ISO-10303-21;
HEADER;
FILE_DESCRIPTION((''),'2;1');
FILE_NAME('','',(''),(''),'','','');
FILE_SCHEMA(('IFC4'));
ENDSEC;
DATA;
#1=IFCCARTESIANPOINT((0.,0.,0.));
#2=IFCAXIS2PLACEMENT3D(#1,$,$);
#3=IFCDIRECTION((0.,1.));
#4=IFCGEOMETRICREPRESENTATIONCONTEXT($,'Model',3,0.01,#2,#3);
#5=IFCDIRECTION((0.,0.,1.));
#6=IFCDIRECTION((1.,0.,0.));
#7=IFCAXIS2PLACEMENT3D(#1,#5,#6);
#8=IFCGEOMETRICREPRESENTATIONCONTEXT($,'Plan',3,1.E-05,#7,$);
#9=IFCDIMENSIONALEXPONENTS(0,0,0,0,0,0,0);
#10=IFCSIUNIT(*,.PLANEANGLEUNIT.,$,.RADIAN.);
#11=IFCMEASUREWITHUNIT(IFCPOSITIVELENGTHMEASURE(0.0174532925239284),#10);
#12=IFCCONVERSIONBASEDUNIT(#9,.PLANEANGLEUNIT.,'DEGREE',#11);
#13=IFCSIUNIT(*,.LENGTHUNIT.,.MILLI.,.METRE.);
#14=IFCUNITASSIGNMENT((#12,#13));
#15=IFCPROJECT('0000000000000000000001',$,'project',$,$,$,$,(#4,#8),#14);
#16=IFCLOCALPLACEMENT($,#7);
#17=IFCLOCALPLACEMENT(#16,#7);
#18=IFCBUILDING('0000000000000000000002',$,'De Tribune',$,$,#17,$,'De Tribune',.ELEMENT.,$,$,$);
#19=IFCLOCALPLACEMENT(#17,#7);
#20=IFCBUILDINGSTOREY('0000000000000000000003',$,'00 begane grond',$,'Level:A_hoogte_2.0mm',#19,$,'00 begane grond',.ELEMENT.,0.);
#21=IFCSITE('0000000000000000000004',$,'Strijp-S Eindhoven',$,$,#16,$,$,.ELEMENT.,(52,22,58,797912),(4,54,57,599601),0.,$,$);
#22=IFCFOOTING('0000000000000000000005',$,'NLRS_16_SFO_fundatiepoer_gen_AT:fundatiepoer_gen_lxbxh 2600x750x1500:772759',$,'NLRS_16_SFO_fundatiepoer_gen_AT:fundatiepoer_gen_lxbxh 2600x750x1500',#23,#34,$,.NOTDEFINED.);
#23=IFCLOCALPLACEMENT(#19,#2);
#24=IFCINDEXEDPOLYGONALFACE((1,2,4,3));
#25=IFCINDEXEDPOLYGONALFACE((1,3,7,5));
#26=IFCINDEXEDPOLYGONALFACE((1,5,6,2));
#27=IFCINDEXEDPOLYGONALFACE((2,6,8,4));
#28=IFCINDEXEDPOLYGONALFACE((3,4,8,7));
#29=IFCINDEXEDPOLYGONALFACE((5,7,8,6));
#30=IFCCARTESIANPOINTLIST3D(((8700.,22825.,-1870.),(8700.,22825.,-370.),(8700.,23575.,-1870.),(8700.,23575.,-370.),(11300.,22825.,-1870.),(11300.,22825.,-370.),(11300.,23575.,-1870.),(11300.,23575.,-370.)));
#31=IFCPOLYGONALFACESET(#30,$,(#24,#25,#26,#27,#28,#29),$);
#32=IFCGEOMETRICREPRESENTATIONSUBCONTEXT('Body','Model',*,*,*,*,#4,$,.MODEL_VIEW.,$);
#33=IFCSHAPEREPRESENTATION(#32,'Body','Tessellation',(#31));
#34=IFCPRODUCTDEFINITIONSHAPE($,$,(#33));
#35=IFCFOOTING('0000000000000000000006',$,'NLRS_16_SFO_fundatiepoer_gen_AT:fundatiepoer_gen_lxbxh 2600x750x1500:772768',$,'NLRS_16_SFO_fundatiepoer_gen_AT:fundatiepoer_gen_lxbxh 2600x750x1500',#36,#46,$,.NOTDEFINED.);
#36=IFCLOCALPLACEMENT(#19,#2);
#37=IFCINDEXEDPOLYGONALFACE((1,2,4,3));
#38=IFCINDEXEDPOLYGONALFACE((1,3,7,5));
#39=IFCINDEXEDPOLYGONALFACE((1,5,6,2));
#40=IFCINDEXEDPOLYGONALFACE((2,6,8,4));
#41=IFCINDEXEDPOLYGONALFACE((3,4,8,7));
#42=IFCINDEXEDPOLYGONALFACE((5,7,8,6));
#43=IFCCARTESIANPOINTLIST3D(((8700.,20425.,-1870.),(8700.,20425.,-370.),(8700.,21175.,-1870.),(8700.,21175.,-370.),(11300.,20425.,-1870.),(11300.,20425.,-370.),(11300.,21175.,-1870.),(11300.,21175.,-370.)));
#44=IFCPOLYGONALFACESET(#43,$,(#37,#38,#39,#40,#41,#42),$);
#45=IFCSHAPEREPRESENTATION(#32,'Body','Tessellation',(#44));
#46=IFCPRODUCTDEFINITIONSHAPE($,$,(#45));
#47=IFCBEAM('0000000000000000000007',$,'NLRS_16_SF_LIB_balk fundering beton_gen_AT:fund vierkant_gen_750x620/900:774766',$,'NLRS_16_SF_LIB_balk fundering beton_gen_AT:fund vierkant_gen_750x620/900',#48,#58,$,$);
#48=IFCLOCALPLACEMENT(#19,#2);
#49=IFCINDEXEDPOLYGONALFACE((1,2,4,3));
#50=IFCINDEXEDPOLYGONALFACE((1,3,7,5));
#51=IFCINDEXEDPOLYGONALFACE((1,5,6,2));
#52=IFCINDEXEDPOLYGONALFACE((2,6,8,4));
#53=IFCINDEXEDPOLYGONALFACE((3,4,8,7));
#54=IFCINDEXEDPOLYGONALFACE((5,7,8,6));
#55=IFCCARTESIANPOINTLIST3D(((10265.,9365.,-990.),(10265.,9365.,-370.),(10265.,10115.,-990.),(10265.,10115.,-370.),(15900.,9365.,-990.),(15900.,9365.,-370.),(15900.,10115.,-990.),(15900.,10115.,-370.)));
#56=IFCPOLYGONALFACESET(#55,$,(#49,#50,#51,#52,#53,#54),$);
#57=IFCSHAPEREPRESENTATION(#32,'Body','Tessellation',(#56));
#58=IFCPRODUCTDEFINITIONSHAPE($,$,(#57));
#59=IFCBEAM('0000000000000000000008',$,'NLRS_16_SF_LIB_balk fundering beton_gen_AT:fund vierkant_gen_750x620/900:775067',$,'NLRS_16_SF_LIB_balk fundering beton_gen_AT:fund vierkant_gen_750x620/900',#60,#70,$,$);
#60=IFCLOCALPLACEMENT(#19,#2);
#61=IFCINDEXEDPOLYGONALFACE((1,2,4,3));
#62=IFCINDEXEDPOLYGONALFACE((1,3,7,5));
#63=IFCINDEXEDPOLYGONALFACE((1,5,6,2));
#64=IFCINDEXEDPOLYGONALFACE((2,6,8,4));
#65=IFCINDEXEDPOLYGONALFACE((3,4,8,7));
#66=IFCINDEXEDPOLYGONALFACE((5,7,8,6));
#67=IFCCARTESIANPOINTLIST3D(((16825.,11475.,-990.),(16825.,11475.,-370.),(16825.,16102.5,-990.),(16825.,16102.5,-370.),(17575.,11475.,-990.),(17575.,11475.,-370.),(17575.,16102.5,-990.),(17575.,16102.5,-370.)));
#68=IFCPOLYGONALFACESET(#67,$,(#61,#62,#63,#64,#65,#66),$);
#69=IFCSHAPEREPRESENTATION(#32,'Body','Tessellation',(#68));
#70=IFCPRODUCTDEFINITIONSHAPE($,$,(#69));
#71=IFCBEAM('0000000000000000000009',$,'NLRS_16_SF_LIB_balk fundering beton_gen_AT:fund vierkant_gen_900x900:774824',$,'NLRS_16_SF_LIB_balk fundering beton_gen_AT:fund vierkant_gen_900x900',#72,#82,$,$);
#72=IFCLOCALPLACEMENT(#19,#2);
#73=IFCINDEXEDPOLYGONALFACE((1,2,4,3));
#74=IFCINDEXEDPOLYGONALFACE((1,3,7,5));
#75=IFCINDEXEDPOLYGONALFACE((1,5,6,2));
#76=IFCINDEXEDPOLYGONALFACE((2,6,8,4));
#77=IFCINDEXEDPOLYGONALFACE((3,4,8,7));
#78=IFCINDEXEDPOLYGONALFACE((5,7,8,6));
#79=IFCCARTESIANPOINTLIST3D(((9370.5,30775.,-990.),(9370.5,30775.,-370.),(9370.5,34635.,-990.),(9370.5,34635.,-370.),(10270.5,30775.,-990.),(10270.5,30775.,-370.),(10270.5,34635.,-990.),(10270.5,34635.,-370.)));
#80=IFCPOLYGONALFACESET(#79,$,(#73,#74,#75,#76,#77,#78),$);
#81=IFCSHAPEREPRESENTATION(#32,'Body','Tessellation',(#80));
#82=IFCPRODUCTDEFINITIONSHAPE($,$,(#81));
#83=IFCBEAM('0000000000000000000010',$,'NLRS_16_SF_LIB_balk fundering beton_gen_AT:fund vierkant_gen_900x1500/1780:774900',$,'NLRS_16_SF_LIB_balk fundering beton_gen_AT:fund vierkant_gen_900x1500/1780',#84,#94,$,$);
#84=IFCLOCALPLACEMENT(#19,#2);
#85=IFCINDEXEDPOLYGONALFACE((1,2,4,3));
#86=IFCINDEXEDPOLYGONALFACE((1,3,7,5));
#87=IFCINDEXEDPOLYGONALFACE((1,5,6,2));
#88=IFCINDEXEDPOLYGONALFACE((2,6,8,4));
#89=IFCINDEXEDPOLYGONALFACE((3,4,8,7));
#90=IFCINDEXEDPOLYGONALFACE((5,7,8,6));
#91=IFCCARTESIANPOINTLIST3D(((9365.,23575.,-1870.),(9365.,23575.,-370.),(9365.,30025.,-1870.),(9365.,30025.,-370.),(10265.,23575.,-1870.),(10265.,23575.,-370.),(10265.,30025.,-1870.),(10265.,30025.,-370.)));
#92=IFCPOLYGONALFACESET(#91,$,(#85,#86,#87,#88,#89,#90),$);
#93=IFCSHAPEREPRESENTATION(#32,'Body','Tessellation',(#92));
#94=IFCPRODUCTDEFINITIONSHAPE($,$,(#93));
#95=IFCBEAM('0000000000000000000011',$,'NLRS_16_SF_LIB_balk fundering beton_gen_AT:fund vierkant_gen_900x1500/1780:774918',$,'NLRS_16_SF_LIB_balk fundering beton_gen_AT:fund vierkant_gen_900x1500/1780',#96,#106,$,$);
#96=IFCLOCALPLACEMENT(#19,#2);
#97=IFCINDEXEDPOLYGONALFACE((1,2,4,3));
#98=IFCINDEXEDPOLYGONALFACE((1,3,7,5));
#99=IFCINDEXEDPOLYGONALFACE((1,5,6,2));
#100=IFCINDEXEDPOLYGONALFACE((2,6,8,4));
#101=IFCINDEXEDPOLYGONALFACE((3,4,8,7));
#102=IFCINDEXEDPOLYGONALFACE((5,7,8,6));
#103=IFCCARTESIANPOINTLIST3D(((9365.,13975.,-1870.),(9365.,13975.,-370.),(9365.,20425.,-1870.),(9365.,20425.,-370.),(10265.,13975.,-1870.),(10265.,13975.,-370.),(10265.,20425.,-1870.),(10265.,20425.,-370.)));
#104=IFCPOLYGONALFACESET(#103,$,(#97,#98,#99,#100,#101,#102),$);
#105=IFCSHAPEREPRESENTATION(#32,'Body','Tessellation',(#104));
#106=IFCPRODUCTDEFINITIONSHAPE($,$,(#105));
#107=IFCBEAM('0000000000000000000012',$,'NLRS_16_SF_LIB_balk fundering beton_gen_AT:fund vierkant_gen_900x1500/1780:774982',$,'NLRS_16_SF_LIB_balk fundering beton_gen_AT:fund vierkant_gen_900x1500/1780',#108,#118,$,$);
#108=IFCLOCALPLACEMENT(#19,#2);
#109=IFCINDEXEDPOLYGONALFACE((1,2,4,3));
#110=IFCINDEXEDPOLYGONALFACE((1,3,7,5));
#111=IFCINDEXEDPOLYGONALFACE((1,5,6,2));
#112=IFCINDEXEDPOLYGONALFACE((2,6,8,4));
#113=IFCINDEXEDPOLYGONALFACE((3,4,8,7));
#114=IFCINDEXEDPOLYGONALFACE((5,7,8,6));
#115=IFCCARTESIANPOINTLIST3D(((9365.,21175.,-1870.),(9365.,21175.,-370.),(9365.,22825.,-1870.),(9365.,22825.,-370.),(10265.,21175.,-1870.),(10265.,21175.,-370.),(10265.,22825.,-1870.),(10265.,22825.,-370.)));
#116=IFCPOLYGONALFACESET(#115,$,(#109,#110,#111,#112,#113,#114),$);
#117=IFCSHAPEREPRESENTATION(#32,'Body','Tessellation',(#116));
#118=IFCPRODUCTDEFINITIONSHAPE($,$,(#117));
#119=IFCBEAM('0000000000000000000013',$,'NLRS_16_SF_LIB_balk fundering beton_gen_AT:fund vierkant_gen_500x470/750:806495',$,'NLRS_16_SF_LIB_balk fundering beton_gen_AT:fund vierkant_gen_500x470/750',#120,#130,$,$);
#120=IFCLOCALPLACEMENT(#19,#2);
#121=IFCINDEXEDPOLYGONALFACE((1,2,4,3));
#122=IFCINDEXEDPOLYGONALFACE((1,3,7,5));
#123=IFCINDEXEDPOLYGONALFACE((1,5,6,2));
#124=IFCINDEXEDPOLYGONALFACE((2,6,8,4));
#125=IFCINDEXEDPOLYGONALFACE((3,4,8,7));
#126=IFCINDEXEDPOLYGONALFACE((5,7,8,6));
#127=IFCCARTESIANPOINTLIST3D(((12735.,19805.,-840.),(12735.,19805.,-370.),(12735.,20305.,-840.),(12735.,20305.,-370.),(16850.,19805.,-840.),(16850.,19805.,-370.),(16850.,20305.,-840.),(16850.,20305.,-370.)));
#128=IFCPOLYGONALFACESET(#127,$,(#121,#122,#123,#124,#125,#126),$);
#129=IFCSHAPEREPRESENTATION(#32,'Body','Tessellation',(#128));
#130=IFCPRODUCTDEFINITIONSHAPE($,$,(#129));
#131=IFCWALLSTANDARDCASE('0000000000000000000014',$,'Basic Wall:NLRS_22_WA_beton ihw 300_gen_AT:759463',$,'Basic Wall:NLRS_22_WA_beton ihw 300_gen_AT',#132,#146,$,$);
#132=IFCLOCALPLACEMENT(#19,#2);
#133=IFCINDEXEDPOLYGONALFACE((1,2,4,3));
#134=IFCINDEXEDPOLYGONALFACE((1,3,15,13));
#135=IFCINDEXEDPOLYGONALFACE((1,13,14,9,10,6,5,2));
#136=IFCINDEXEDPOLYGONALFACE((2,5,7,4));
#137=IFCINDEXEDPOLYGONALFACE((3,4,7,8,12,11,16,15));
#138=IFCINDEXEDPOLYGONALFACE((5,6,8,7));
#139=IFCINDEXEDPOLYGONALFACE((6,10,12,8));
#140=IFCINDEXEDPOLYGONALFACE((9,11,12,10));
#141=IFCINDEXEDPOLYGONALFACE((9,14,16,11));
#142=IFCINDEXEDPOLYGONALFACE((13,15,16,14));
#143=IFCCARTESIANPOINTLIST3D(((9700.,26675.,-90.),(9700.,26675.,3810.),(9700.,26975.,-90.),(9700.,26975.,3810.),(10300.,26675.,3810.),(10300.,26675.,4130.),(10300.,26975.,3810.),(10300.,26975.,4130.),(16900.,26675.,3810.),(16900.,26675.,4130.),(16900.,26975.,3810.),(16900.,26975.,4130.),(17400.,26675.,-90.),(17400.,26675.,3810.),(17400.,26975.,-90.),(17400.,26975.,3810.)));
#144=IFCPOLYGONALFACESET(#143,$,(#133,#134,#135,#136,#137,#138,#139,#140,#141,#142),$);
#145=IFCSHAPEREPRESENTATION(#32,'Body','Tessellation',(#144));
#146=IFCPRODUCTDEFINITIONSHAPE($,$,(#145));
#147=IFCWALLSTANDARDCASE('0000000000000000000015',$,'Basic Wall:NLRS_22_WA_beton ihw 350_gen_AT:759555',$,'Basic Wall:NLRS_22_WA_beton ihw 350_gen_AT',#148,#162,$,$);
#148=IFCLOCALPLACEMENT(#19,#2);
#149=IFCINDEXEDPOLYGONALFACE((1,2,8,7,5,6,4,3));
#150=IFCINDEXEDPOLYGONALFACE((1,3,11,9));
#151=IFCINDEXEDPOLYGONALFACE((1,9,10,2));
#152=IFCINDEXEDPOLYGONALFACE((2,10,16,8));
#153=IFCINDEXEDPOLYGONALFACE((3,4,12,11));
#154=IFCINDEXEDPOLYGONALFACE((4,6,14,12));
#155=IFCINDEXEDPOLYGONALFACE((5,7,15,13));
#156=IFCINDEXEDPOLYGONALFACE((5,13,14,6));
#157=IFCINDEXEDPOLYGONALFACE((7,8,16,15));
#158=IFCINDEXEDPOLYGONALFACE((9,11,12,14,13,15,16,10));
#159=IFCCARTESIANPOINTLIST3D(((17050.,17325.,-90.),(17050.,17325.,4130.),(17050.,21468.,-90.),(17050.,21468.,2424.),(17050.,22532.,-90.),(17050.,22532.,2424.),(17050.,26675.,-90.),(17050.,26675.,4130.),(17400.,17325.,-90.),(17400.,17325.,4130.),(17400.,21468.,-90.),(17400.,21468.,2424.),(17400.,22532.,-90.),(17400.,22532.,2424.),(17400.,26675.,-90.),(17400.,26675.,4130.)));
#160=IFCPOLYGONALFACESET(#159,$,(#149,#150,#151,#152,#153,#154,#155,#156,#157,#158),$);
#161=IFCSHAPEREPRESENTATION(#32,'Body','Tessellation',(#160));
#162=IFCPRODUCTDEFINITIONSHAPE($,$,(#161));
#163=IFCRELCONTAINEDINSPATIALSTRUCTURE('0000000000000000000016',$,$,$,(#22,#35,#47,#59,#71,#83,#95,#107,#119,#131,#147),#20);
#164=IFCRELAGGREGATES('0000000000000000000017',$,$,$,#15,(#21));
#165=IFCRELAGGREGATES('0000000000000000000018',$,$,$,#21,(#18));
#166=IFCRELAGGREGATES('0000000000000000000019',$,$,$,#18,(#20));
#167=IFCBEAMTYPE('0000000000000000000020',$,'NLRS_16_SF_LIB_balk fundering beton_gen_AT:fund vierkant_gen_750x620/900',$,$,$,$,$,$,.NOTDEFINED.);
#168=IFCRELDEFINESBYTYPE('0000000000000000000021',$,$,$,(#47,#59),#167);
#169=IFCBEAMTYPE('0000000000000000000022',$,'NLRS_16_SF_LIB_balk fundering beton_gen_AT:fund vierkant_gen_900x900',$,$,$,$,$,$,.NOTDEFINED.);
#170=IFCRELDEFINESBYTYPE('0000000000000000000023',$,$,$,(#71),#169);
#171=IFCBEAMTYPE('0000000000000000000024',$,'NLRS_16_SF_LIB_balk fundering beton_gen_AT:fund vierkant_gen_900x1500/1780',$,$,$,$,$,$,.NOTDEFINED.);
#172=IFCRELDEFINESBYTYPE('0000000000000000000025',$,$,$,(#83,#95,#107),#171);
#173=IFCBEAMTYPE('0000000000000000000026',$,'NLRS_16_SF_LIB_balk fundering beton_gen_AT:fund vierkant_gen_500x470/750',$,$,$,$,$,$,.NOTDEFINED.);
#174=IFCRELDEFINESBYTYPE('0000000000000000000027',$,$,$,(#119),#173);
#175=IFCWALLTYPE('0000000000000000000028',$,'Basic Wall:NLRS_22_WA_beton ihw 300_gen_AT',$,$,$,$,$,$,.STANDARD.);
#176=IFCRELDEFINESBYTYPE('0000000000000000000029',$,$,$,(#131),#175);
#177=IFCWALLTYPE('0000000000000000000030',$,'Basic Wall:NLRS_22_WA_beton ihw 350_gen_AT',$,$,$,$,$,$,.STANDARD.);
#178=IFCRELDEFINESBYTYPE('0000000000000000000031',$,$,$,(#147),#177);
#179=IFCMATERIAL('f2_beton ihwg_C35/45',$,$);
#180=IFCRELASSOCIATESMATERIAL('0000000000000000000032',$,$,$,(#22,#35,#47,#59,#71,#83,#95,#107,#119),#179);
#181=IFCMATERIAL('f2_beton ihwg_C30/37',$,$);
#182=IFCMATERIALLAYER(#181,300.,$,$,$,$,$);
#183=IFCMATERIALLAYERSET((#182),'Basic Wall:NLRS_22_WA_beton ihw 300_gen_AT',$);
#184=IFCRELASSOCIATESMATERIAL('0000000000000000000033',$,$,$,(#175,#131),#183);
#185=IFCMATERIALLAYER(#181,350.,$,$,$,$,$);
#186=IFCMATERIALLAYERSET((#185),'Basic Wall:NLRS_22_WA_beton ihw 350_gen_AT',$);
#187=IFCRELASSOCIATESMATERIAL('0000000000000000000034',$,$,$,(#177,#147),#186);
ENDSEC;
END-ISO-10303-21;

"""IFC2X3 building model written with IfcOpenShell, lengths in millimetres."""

from ifc_helpers import new_model, entity, si_unit, converted_unit, direction, frame, frame_2d, origin, origin_with_axes, origin_2d_with_axis, place, context, subcontext, project, spatial, rectangle, extrude, source, transform, mapped, material, layer, layer_set, layer_usage, type_object, element, save


model = new_model("IFC2X3")

# Units and contexts
model_context = context("Model", 3, precision=0.01, world=origin(), true_north=direction((0.0, 1.0)))
plan_context = context("Plan", 3, precision=1e-05, world=origin_with_axes())
body_context = subcontext(model_context, "Body", "Model", "MODEL_VIEW")
ifc_project = project(units=[converted_unit("PLANEANGLEUNIT", "DEGREE", entity("IfcPositiveLengthMeasure", 0.0174532925239284), si_unit("PLANEANGLEUNIT", "RADIAN"), dimensions=[0, 0, 0, 0, 0, 0, 0]), si_unit("LENGTHUNIT", "METRE", prefix="MILLI")], contexts=[model_context, plan_context])

# Site, building, storey
site_placement = place(None, origin_with_axes())
site = spatial("IfcSite", under=ifc_project, at=site_placement, Name="Strijp-S Eindhoven", CompositionType="ELEMENT", RefLatitude=(52, 22, 58, 797912), RefLongitude=(4, 54, 57, 599601), RefElevation=0.0)
building_placement = place(site_placement, origin_with_axes())
building = spatial("IfcBuilding", under=site, at=building_placement, Name="De Tribune", LongName="De Tribune", CompositionType="ELEMENT")
storey_placement = place(building_placement, origin_with_axes())
storey = spatial("IfcBuildingStorey", under=building, at=storey_placement, Name="00 begane grond", ObjectType="Level:A_hoogte_2.0mm", LongName="00 begane grond", CompositionType="ELEMENT", Elevation=0.0)

# Footings
ifc_material_1 = material(Name="f2_beton ihwg_C35/45")
shared_shape = source(origin(), body_context, "Body", "SweptSolid", [
    extrude(rectangle(XDim=750.0, YDim=2600.0, at=origin_2d_with_axis()), frame((0.0, 0.0, -1500.0), z_axis=(0.0, 0.0, 1.0), x_axis=(-1.0, 0.0, 0.0)), (0.0, 0.0, 1.0), 1500.0),
])
for number, where, z_axis, x_axis, name in (
    (1, (10000.0, 23200.0, -370.0), (0.0, 0.0, 1.0), (0.0, 1.0, 0.0), "NLRS_16_SFO_fundatiepoer_gen_AT:fundatiepoer_gen_lxbxh 2600x750x1500:772759"),
    (2, (10000.0, 20800.0, -370.0), (0.0, 0.0, 1.0), (0.0, 1.0, 0.0), "NLRS_16_SFO_fundatiepoer_gen_AT:fundatiepoer_gen_lxbxh 2600x750x1500:772768"),
):
    element("IfcFooting", number, at=place(storey_placement, frame(where, z_axis=z_axis, x_axis=x_axis)), inside=storey, material=ifc_material_1, Name=name, ObjectType="NLRS_16_SFO_fundatiepoer_gen_AT:fundatiepoer_gen_lxbxh 2600x750x1500", PredefinedType="NOTDEFINED", context=body_context, shape_type="MappedRepresentation", body=[
        mapped(shared_shape, transform((0.0, 0.0, 0.0), scale=1.0)),
    ])

# Beams
beam_type_1 = type_object("IfcBeamType", Name="NLRS_16_SF_LIB_balk fundering beton_gen_AT:fund vierkant_gen_750x620/900", PredefinedType="NOTDEFINED")
beam_1_placement = place(storey_placement, frame((9740.0, 9740.0, 0.0), z_axis=(0.0, 0.0, 1.0), x_axis=(1.0, 0.0, 0.0)))
element("IfcBeam", 3, at=beam_1_placement, inside=storey, type_object=beam_type_1, material=ifc_material_1, Name="NLRS_16_SF_LIB_balk fundering beton_gen_AT:fund vierkant_gen_750x620/900:774766", ObjectType="NLRS_16_SF_LIB_balk fundering beton_gen_AT:fund vierkant_gen_750x620/900", context=body_context, shape_type="SweptSolid", body=[
    extrude(rectangle(XDim=620.0, YDim=750.0, at=frame_2d((0.0, 0.0), x_axis=(1.0, 0.0))), frame((525.0, 0.0, -680.0), z_axis=(1.0, 0.0, 0.0), x_axis=(0.0, 0.0, -1.0)), (0.0, 0.0, 1.0), 5635.0),
])
beam_2_placement = place(storey_placement, frame((17200.0, 11475.0, 0.0), z_axis=(0.0, 0.0, 1.0), x_axis=(0.0, 1.0, 0.0)))
element("IfcBeam", 4, at=beam_2_placement, inside=storey, type_object=beam_type_1, material=ifc_material_1, Name="NLRS_16_SF_LIB_balk fundering beton_gen_AT:fund vierkant_gen_750x620/900:775067", ObjectType="NLRS_16_SF_LIB_balk fundering beton_gen_AT:fund vierkant_gen_750x620/900", context=body_context, shape_type="SweptSolid", body=[
    extrude(rectangle(XDim=620.0, YDim=750.0, at=origin_2d_with_axis()), frame((0.0, 0.0, -680.0), z_axis=(1.0, 0.0, 0.0), x_axis=(0.0, 0.0, -1.0)), (0.0, 0.0, 1.0), 4627.5),
])
beam_type_2 = type_object("IfcBeamType", Name="NLRS_16_SF_LIB_balk fundering beton_gen_AT:fund vierkant_gen_900x900", PredefinedType="NOTDEFINED")
beam_3_placement = place(storey_placement, frame((9820.5, 30775.0, 0.0), z_axis=(0.0, 0.0, 1.0), x_axis=(0.0, 1.0, 0.0)))
element("IfcBeam", 5, at=beam_3_placement, inside=storey, type_object=beam_type_2, material=ifc_material_1, Name="NLRS_16_SF_LIB_balk fundering beton_gen_AT:fund vierkant_gen_900x900:774824", ObjectType="NLRS_16_SF_LIB_balk fundering beton_gen_AT:fund vierkant_gen_900x900", context=body_context, shape_type="SweptSolid", body=[
    extrude(rectangle(XDim=620.0, YDim=900.0, at=origin_2d_with_axis()), frame((0.0, 0.0, -680.0), z_axis=(1.0, 0.0, 0.0), x_axis=(0.0, 0.0, -1.0)), (0.0, 0.0, 1.0), 3860.0),
])
beam_type_3 = type_object("IfcBeamType", Name="NLRS_16_SF_LIB_balk fundering beton_gen_AT:fund vierkant_gen_900x1500/1780", PredefinedType="NOTDEFINED")
for number, where, z_axis, x_axis, name in (
    (6, (9815.0, 23575.0, 0.0), (0.0, 0.0, 1.0), (0.0, 1.0, 0.0), "NLRS_16_SF_LIB_balk fundering beton_gen_AT:fund vierkant_gen_900x1500/1780:774900"),
    (7, (9815.0, 13975.0, 0.0), (0.0, 0.0, 1.0), (0.0, 1.0, 0.0), "NLRS_16_SF_LIB_balk fundering beton_gen_AT:fund vierkant_gen_900x1500/1780:774918"),
):
    element("IfcBeam", number, at=place(storey_placement, frame(where, z_axis=z_axis, x_axis=x_axis)), inside=storey, type_object=beam_type_3, material=ifc_material_1, Name=name, ObjectType="NLRS_16_SF_LIB_balk fundering beton_gen_AT:fund vierkant_gen_900x1500/1780", context=body_context, shape_type="SweptSolid", body=[
        extrude(rectangle(XDim=1500.0, YDim=900.0, at=frame_2d((0.0, 0.0), x_axis=(1.0, 0.0))), frame((0.0, 0.0, -1120.0), z_axis=(1.0, 0.0, 0.0), x_axis=(0.0, 0.0, -1.0)), (0.0, 0.0, 1.0), 6450.0),
    ])
beam_4_placement = place(storey_placement, frame((9815.0, 21175.0, 0.0), z_axis=(0.0, 0.0, 1.0), x_axis=(0.0, 1.0, 0.0)))
element("IfcBeam", 8, at=beam_4_placement, inside=storey, type_object=beam_type_3, material=ifc_material_1, Name="NLRS_16_SF_LIB_balk fundering beton_gen_AT:fund vierkant_gen_900x1500/1780:774982", ObjectType="NLRS_16_SF_LIB_balk fundering beton_gen_AT:fund vierkant_gen_900x1500/1780", context=body_context, shape_type="SweptSolid", body=[
    extrude(rectangle(XDim=1500.0, YDim=900.0, at=frame_2d((0.0, 0.0), x_axis=(1.0, 0.0))), frame((0.0, 0.0, -1120.0), z_axis=(1.0, 0.0, 0.0), x_axis=(0.0, 0.0, -1.0)), (0.0, 0.0, 1.0), 1650.0),
])
beam_type_4 = type_object("IfcBeamType", Name="NLRS_16_SF_LIB_balk fundering beton_gen_AT:fund vierkant_gen_500x470/750", PredefinedType="NOTDEFINED")
beam_5_placement = place(storey_placement, frame((12485.0, 20055.0, 0.0), z_axis=(0.0, 0.0, 1.0), x_axis=(1.0, 0.0, 0.0)))
element("IfcBeam", 9, at=beam_5_placement, inside=storey, type_object=beam_type_4, material=ifc_material_1, Name="NLRS_16_SF_LIB_balk fundering beton_gen_AT:fund vierkant_gen_500x470/750:806495", ObjectType="NLRS_16_SF_LIB_balk fundering beton_gen_AT:fund vierkant_gen_500x470/750", context=body_context, shape_type="SweptSolid", body=[
    extrude(rectangle(XDim=470.0, YDim=500.0, at=frame_2d((0.0, 0.0), x_axis=(1.0, 0.0))), frame((250.0, 0.0, -605.0), z_axis=(1.0, 0.0, 0.0), x_axis=(0.0, 0.0, -1.0)), (0.0, 0.0, 1.0), 4115.0),
])

# Wall, openings
ifc_material_2 = material(Name="f2_beton ihwg_C30/37")
ifc_layer_1 = layer(ifc_material_2, 300.0)
ifc_layer_set_1 = layer_set([ifc_layer_1], Name="Basic Wall:NLRS_22_WA_beton ihw 300_gen_AT")
ifc_layer_usage_1 = layer_usage(ifc_layer_set_1, "AXIS2", "NEGATIVE", 150.0)
wall_type_1 = type_object("IfcWallType", Name="Basic Wall:NLRS_22_WA_beton ihw 300_gen_AT", PredefinedType="STANDARD", material=ifc_layer_set_1)
wall_1_placement = place(storey_placement, frame((9700.0, 26825.0, -90.0), z_axis=(0.0, 0.0, 1.0), x_axis=(1.0, 0.0, 0.0)))
wall_1 = element("IfcWallStandardCase", 10, at=wall_1_placement, inside=storey, type_object=wall_type_1, material=ifc_layer_usage_1, Name="Basic Wall:NLRS_22_WA_beton ihw 300_gen_AT:759463", ObjectType="Basic Wall:NLRS_22_WA_beton ihw 300_gen_AT", context=body_context, shape_type="SweptSolid", body=[
    extrude(rectangle(XDim=7700.0, YDim=300.0, at=frame_2d((3850.0, 0.0), x_axis=(-1.0, 0.0))), origin(), (0.0, 0.0, 1.0), 4220.0),
])
opening_1_placement = place(wall_1_placement, origin_with_axes())
element("IfcOpeningElement", 11, at=opening_1_placement, cuts=wall_1, ObjectType="Opening", context=body_context, shape_type="SweptSolid", body=[
    extrude(rectangle(XDim=320.0, YDim=500.0, at=frame_2d((0.0, 0.0), x_axis=(1.0, 0.0))), frame((7450.0, 150.0, 4060.0), z_axis=(0.0, -1.0, 0.0), x_axis=(0.0, 0.0, 1.0)), (0.0, 0.0, 1.0), 300.0),
])
opening_2_placement = place(wall_1_placement, origin_with_axes())
element("IfcOpeningElement", 12, at=opening_2_placement, cuts=wall_1, ObjectType="Opening", context=body_context, shape_type="SweptSolid", body=[
    extrude(rectangle(XDim=320.0, YDim=600.0, at=frame_2d((0.0, 0.0), x_axis=(0.0, 1.0))), frame((300.0, 150.0, 4060.0), z_axis=(0.0, -1.0, 0.0), x_axis=(-1.0, 0.0, 0.0)), (0.0, 0.0, 1.0), 300.0),
])

# Wall, opening
ifc_layer_2 = layer(ifc_material_2, 350.0)
ifc_layer_set_2 = layer_set([ifc_layer_2], Name="Basic Wall:NLRS_22_WA_beton ihw 350_gen_AT")
ifc_layer_usage_2 = layer_usage(ifc_layer_set_2, "AXIS2", "NEGATIVE", 175.0)
wall_type_2 = type_object("IfcWallType", Name="Basic Wall:NLRS_22_WA_beton ihw 350_gen_AT", PredefinedType="STANDARD", material=ifc_layer_set_2)
wall_2_placement = place(storey_placement, frame((17225.0, 26675.0, -90.0), z_axis=(0.0, 0.0, 1.0), x_axis=(0.0, -1.0, 0.0)))
wall_2 = element("IfcWallStandardCase", 13, at=wall_2_placement, inside=storey, type_object=wall_type_2, material=ifc_layer_usage_2, Name="Basic Wall:NLRS_22_WA_beton ihw 350_gen_AT:759555", ObjectType="Basic Wall:NLRS_22_WA_beton ihw 350_gen_AT", context=body_context, shape_type="SweptSolid", body=[
    extrude(rectangle(XDim=9350.0, YDim=350.0, at=frame_2d((4675.0, 0.0), x_axis=(1.0, 0.0))), origin(), (0.0, 0.0, 1.0), 4220.0),
])
opening_3_placement = place(wall_2_placement, frame((26675.0, -17225.0, 90.0), z_axis=(0.0, 0.0, 1.0), x_axis=(0.0, 1.0, 0.0)))
element("IfcOpeningElement", 14, at=opening_3_placement, cuts=wall_2, ObjectType="Opening", context=body_context, shape_type="SweptSolid", body=[
    extrude(rectangle(XDim=2514.0, YDim=1064.0, at=frame_2d((0.0, 0.0), x_axis=(0.0, 1.0))), frame((15526.0, 22000.0, 1167.0), z_axis=(1.0, 0.0, 0.0), x_axis=(0.0, -1.0, 0.0)), (0.0, 0.0, 1.0), 3048.0),
])

save(model, "model.ifc")
